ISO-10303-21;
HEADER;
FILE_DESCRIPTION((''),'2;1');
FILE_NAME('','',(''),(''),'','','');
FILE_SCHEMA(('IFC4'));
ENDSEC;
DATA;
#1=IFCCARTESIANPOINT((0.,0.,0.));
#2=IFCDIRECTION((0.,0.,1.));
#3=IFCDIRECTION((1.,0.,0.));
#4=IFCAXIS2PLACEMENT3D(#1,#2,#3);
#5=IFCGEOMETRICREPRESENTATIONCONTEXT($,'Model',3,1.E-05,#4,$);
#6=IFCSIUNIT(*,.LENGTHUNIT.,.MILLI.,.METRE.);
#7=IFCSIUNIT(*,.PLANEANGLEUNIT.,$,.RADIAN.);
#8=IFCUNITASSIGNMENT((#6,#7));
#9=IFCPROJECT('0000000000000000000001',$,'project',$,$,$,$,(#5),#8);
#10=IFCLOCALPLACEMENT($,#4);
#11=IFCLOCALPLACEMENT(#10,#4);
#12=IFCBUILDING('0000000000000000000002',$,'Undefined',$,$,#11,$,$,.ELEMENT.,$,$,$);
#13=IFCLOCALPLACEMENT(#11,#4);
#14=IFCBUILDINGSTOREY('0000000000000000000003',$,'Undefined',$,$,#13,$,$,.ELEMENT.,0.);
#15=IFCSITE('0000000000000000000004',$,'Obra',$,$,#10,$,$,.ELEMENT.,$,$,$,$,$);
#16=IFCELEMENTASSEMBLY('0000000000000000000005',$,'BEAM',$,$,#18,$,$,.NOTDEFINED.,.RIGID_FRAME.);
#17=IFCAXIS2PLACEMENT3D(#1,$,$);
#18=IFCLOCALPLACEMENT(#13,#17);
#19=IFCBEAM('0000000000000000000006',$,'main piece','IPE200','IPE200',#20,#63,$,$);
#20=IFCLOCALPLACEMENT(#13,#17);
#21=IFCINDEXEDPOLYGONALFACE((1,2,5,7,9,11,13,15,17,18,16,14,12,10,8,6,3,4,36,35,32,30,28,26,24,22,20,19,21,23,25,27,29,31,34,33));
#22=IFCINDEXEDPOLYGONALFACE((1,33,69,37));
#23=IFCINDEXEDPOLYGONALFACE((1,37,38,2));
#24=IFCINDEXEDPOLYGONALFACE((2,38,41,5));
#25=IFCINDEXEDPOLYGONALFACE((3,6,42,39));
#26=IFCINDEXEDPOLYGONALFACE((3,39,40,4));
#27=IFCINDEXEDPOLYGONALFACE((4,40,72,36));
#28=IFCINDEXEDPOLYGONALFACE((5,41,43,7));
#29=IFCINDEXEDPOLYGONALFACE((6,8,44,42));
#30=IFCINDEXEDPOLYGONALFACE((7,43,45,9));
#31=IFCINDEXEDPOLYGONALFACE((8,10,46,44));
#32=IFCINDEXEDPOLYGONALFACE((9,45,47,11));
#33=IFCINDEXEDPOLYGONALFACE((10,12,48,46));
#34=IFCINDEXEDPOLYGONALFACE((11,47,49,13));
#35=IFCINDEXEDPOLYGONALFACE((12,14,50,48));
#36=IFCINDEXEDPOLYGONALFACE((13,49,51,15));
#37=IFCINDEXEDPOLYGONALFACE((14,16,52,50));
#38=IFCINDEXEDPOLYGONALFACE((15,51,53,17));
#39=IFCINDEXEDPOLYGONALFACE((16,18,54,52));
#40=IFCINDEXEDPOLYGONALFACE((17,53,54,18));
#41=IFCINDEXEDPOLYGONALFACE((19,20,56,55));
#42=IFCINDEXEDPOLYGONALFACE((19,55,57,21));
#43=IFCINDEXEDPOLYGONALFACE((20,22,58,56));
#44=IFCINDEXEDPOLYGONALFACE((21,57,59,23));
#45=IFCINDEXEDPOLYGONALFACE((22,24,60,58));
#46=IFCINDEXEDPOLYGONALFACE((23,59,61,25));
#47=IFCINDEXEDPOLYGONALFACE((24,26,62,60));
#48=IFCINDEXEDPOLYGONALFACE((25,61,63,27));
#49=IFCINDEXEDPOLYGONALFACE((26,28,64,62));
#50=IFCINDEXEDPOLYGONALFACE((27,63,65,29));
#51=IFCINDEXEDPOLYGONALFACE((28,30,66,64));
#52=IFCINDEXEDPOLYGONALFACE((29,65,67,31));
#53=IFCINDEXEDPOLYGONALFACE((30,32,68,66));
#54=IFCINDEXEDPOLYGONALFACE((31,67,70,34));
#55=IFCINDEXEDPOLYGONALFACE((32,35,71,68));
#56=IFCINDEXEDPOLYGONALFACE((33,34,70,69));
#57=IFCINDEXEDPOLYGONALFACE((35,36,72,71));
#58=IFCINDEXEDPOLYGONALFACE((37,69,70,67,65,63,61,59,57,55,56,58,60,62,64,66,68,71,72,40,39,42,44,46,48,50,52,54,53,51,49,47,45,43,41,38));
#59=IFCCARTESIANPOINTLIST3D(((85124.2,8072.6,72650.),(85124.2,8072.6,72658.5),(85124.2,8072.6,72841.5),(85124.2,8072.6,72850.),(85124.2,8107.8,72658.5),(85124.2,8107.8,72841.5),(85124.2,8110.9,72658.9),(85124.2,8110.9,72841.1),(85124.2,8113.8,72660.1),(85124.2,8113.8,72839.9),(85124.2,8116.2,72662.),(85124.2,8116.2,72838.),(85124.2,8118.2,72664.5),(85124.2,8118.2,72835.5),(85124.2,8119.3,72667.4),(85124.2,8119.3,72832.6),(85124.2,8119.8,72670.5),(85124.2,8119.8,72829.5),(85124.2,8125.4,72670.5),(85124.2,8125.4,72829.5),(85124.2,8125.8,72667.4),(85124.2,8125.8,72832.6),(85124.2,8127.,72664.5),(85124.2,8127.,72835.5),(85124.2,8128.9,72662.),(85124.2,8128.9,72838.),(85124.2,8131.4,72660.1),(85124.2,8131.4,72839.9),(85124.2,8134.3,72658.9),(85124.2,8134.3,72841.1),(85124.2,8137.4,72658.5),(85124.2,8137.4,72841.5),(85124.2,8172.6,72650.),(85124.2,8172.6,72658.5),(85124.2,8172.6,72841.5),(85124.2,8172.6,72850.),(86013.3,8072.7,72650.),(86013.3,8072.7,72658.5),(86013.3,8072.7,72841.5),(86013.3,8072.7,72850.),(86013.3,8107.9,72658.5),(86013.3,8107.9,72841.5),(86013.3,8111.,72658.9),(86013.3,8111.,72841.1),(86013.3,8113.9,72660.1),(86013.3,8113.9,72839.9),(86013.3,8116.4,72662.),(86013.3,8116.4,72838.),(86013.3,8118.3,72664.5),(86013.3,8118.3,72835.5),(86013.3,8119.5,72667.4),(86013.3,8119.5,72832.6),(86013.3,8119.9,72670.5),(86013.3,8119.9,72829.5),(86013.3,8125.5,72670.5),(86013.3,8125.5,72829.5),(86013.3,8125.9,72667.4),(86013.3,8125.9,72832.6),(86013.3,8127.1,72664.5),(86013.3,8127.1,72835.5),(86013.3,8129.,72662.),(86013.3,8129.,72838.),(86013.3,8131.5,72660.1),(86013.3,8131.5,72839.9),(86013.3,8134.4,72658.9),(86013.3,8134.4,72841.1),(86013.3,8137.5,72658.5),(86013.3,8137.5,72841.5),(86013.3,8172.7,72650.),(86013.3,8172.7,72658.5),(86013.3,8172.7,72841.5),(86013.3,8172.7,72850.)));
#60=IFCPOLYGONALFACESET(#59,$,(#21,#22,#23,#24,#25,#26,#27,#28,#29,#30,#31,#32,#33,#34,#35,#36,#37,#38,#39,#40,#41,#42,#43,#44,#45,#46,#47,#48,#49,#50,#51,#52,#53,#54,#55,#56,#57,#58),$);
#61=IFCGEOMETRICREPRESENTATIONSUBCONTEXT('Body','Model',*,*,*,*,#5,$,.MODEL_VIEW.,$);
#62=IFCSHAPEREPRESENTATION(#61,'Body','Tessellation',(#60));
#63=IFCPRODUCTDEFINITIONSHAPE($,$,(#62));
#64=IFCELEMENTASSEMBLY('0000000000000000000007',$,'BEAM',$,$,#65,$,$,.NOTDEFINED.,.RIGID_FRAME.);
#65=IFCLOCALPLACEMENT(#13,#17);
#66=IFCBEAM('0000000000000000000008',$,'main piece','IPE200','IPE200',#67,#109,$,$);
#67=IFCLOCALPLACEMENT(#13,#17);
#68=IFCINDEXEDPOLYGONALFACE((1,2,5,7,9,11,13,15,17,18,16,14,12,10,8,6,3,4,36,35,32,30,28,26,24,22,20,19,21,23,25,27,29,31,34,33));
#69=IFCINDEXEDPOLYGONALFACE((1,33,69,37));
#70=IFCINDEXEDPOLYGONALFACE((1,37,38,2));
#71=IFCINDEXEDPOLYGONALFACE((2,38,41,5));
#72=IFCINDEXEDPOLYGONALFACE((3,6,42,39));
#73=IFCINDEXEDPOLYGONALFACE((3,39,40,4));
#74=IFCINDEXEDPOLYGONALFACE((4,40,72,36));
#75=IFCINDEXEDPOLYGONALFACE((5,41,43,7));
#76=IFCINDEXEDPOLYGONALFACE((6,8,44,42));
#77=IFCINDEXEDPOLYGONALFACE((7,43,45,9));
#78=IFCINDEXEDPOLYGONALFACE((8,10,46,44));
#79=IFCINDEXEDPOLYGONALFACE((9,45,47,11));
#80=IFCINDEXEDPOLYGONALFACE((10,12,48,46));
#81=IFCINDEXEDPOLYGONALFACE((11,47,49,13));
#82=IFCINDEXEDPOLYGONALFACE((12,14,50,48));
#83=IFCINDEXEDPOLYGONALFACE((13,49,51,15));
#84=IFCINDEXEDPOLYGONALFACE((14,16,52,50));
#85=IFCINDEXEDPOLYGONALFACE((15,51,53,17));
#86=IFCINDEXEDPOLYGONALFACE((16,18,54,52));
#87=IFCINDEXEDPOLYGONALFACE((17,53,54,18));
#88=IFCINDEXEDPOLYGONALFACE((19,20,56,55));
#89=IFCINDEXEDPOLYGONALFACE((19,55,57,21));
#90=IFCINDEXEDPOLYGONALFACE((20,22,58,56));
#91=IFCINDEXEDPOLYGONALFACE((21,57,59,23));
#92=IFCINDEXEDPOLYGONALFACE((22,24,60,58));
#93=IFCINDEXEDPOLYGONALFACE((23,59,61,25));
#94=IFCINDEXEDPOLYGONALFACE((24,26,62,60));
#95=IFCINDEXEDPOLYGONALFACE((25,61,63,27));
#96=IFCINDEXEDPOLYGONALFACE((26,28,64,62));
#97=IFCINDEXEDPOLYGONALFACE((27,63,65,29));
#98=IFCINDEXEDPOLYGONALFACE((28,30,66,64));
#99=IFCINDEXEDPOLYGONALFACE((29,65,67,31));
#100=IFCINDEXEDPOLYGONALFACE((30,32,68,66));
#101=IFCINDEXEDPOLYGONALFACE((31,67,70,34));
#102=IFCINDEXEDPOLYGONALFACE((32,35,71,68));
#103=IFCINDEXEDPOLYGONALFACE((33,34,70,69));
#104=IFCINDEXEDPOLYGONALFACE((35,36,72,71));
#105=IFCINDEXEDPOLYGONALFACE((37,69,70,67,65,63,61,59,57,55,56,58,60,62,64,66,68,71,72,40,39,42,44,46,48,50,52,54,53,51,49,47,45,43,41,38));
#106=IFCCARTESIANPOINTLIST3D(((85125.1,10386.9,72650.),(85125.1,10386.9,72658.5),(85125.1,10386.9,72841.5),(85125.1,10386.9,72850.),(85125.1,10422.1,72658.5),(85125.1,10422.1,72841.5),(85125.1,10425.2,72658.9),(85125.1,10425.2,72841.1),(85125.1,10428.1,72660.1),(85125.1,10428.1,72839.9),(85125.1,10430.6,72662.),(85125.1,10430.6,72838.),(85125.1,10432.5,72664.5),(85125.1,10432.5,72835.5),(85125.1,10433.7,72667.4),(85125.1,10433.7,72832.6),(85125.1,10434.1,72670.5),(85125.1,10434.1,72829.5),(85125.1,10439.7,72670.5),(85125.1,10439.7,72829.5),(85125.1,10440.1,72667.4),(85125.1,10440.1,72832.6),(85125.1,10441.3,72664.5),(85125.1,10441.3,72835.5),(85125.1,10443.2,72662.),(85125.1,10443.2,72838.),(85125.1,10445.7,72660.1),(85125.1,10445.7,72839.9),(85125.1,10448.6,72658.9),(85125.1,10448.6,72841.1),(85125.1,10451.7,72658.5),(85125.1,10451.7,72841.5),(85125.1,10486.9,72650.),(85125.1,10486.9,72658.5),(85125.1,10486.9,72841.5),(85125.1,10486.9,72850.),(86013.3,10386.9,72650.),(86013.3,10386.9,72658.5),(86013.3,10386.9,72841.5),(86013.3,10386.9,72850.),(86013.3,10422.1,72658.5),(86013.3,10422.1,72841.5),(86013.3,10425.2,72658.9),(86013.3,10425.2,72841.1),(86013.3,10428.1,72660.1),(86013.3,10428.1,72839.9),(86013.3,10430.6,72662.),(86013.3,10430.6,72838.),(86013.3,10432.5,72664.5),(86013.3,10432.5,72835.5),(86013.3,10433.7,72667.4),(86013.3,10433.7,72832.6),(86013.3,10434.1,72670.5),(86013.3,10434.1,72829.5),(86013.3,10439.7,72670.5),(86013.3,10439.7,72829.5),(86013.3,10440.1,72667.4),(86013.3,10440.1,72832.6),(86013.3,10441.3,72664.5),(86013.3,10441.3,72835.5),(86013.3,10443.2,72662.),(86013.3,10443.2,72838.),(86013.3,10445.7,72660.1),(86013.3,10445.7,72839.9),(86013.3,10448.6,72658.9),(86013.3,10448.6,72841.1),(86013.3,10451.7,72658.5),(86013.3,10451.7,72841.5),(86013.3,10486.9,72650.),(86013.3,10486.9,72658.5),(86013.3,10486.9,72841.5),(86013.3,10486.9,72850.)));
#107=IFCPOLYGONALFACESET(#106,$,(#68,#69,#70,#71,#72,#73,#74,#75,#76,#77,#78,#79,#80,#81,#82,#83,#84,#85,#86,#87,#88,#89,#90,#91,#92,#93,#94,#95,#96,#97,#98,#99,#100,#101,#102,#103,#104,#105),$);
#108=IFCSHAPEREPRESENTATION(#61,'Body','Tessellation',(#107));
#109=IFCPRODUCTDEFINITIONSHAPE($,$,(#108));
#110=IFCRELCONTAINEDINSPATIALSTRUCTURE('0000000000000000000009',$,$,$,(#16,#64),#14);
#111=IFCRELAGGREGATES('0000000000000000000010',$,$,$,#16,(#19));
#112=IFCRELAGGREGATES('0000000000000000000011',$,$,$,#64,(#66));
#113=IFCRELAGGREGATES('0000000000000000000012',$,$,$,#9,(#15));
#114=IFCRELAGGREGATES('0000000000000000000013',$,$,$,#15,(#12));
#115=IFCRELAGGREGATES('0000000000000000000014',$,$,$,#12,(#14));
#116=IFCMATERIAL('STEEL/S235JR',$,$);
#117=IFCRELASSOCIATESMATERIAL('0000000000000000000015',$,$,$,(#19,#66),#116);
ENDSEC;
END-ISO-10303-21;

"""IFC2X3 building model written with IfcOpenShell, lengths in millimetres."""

from ifc_helpers import new_model, si_unit, frame, origin_with_axes, origin_2d_with_axis, place, context, subcontext, project, spatial, i_section, extrude, material, element, aggregate, save


model = new_model("IFC2X3")

# Units and contexts
model_context = context("Model", 3, precision=1e-05, world=origin_with_axes())
body_context = subcontext(model_context, "Body", "Model", "MODEL_VIEW")
ifc_project = project(units=[si_unit("LENGTHUNIT", "METRE", prefix="MILLI"), si_unit("PLANEANGLEUNIT", "RADIAN")], contexts=[model_context])

# Site, building, storey
site_placement = place(None, origin_with_axes())
site = spatial("IfcSite", under=ifc_project, at=site_placement, Name="Obra", CompositionType="ELEMENT")
building_placement = place(site_placement, origin_with_axes())
building = spatial("IfcBuilding", under=site, at=building_placement, Name="Undefined", CompositionType="ELEMENT")
storey_placement = place(building_placement, origin_with_axes())
storey = spatial("IfcBuildingStorey", under=building, at=storey_placement, Name="Undefined", CompositionType="ELEMENT", Elevation=0.0)

# Element assemblies, beams
ifc_material = material(Name="STEEL/S235JR")
assembly_1_placement = place(storey_placement, origin_with_axes())
assembly_1 = element("IfcElementAssembly", 1, at=assembly_1_placement, inside=storey, Name="BEAM", AssemblyPlace="NOTDEFINED", PredefinedType="RIGID_FRAME")
beam_1_placement = place(assembly_1_placement, frame((85124.2, 8122.6, 72750.0), z_axis=(0.0, 0.0, 1.0), x_axis=(1.0, 0.000161, 0.0)))
beam_1 = element("IfcBeam", 2, at=beam_1_placement, material=ifc_material, Name="main piece", Description="IPE200", ObjectType="IPE200", context=body_context, shape_type="SweptSolid", body=[
    extrude(i_section(OverallWidth=100.0, OverallDepth=200.0, WebThickness=5.6, FlangeThickness=8.5, FilletRadius=12.0, at=origin_2d_with_axis()), frame((889.1, 0.0, 0.0), z_axis=(-1.0, 0.0, 0.0), x_axis=(0.0, -1.0, 0.0)), (0.0, 0.0, 1.0), 889.1),
])
aggregate(assembly_1, [beam_1])
assembly_2_placement = place(storey_placement, origin_with_axes())
assembly_2 = element("IfcElementAssembly", 3, at=assembly_2_placement, inside=storey, Name="BEAM", AssemblyPlace="NOTDEFINED", PredefinedType="RIGID_FRAME")
beam_2_placement = place(assembly_2_placement, frame((85125.1, 10436.9, 72750.0), z_axis=(0.0, 0.0, 1.0), x_axis=(1.0, 0.0, 0.0)))
beam_2 = element("IfcBeam", 4, at=beam_2_placement, material=ifc_material, Name="main piece", Description="IPE200", ObjectType="IPE200", context=body_context, shape_type="SweptSolid", body=[
    extrude(i_section(OverallWidth=100.0, OverallDepth=200.0, WebThickness=5.6, FlangeThickness=8.5, FilletRadius=12.0, at=origin_2d_with_axis()), frame((888.2, 0.0, 0.0), z_axis=(-1.0, 0.0, 0.0), x_axis=(0.0, -1.0, 0.0)), (0.0, 0.0, 1.0), 888.2),
])
aggregate(assembly_2, [beam_2])

save(model, "model.ifc")
